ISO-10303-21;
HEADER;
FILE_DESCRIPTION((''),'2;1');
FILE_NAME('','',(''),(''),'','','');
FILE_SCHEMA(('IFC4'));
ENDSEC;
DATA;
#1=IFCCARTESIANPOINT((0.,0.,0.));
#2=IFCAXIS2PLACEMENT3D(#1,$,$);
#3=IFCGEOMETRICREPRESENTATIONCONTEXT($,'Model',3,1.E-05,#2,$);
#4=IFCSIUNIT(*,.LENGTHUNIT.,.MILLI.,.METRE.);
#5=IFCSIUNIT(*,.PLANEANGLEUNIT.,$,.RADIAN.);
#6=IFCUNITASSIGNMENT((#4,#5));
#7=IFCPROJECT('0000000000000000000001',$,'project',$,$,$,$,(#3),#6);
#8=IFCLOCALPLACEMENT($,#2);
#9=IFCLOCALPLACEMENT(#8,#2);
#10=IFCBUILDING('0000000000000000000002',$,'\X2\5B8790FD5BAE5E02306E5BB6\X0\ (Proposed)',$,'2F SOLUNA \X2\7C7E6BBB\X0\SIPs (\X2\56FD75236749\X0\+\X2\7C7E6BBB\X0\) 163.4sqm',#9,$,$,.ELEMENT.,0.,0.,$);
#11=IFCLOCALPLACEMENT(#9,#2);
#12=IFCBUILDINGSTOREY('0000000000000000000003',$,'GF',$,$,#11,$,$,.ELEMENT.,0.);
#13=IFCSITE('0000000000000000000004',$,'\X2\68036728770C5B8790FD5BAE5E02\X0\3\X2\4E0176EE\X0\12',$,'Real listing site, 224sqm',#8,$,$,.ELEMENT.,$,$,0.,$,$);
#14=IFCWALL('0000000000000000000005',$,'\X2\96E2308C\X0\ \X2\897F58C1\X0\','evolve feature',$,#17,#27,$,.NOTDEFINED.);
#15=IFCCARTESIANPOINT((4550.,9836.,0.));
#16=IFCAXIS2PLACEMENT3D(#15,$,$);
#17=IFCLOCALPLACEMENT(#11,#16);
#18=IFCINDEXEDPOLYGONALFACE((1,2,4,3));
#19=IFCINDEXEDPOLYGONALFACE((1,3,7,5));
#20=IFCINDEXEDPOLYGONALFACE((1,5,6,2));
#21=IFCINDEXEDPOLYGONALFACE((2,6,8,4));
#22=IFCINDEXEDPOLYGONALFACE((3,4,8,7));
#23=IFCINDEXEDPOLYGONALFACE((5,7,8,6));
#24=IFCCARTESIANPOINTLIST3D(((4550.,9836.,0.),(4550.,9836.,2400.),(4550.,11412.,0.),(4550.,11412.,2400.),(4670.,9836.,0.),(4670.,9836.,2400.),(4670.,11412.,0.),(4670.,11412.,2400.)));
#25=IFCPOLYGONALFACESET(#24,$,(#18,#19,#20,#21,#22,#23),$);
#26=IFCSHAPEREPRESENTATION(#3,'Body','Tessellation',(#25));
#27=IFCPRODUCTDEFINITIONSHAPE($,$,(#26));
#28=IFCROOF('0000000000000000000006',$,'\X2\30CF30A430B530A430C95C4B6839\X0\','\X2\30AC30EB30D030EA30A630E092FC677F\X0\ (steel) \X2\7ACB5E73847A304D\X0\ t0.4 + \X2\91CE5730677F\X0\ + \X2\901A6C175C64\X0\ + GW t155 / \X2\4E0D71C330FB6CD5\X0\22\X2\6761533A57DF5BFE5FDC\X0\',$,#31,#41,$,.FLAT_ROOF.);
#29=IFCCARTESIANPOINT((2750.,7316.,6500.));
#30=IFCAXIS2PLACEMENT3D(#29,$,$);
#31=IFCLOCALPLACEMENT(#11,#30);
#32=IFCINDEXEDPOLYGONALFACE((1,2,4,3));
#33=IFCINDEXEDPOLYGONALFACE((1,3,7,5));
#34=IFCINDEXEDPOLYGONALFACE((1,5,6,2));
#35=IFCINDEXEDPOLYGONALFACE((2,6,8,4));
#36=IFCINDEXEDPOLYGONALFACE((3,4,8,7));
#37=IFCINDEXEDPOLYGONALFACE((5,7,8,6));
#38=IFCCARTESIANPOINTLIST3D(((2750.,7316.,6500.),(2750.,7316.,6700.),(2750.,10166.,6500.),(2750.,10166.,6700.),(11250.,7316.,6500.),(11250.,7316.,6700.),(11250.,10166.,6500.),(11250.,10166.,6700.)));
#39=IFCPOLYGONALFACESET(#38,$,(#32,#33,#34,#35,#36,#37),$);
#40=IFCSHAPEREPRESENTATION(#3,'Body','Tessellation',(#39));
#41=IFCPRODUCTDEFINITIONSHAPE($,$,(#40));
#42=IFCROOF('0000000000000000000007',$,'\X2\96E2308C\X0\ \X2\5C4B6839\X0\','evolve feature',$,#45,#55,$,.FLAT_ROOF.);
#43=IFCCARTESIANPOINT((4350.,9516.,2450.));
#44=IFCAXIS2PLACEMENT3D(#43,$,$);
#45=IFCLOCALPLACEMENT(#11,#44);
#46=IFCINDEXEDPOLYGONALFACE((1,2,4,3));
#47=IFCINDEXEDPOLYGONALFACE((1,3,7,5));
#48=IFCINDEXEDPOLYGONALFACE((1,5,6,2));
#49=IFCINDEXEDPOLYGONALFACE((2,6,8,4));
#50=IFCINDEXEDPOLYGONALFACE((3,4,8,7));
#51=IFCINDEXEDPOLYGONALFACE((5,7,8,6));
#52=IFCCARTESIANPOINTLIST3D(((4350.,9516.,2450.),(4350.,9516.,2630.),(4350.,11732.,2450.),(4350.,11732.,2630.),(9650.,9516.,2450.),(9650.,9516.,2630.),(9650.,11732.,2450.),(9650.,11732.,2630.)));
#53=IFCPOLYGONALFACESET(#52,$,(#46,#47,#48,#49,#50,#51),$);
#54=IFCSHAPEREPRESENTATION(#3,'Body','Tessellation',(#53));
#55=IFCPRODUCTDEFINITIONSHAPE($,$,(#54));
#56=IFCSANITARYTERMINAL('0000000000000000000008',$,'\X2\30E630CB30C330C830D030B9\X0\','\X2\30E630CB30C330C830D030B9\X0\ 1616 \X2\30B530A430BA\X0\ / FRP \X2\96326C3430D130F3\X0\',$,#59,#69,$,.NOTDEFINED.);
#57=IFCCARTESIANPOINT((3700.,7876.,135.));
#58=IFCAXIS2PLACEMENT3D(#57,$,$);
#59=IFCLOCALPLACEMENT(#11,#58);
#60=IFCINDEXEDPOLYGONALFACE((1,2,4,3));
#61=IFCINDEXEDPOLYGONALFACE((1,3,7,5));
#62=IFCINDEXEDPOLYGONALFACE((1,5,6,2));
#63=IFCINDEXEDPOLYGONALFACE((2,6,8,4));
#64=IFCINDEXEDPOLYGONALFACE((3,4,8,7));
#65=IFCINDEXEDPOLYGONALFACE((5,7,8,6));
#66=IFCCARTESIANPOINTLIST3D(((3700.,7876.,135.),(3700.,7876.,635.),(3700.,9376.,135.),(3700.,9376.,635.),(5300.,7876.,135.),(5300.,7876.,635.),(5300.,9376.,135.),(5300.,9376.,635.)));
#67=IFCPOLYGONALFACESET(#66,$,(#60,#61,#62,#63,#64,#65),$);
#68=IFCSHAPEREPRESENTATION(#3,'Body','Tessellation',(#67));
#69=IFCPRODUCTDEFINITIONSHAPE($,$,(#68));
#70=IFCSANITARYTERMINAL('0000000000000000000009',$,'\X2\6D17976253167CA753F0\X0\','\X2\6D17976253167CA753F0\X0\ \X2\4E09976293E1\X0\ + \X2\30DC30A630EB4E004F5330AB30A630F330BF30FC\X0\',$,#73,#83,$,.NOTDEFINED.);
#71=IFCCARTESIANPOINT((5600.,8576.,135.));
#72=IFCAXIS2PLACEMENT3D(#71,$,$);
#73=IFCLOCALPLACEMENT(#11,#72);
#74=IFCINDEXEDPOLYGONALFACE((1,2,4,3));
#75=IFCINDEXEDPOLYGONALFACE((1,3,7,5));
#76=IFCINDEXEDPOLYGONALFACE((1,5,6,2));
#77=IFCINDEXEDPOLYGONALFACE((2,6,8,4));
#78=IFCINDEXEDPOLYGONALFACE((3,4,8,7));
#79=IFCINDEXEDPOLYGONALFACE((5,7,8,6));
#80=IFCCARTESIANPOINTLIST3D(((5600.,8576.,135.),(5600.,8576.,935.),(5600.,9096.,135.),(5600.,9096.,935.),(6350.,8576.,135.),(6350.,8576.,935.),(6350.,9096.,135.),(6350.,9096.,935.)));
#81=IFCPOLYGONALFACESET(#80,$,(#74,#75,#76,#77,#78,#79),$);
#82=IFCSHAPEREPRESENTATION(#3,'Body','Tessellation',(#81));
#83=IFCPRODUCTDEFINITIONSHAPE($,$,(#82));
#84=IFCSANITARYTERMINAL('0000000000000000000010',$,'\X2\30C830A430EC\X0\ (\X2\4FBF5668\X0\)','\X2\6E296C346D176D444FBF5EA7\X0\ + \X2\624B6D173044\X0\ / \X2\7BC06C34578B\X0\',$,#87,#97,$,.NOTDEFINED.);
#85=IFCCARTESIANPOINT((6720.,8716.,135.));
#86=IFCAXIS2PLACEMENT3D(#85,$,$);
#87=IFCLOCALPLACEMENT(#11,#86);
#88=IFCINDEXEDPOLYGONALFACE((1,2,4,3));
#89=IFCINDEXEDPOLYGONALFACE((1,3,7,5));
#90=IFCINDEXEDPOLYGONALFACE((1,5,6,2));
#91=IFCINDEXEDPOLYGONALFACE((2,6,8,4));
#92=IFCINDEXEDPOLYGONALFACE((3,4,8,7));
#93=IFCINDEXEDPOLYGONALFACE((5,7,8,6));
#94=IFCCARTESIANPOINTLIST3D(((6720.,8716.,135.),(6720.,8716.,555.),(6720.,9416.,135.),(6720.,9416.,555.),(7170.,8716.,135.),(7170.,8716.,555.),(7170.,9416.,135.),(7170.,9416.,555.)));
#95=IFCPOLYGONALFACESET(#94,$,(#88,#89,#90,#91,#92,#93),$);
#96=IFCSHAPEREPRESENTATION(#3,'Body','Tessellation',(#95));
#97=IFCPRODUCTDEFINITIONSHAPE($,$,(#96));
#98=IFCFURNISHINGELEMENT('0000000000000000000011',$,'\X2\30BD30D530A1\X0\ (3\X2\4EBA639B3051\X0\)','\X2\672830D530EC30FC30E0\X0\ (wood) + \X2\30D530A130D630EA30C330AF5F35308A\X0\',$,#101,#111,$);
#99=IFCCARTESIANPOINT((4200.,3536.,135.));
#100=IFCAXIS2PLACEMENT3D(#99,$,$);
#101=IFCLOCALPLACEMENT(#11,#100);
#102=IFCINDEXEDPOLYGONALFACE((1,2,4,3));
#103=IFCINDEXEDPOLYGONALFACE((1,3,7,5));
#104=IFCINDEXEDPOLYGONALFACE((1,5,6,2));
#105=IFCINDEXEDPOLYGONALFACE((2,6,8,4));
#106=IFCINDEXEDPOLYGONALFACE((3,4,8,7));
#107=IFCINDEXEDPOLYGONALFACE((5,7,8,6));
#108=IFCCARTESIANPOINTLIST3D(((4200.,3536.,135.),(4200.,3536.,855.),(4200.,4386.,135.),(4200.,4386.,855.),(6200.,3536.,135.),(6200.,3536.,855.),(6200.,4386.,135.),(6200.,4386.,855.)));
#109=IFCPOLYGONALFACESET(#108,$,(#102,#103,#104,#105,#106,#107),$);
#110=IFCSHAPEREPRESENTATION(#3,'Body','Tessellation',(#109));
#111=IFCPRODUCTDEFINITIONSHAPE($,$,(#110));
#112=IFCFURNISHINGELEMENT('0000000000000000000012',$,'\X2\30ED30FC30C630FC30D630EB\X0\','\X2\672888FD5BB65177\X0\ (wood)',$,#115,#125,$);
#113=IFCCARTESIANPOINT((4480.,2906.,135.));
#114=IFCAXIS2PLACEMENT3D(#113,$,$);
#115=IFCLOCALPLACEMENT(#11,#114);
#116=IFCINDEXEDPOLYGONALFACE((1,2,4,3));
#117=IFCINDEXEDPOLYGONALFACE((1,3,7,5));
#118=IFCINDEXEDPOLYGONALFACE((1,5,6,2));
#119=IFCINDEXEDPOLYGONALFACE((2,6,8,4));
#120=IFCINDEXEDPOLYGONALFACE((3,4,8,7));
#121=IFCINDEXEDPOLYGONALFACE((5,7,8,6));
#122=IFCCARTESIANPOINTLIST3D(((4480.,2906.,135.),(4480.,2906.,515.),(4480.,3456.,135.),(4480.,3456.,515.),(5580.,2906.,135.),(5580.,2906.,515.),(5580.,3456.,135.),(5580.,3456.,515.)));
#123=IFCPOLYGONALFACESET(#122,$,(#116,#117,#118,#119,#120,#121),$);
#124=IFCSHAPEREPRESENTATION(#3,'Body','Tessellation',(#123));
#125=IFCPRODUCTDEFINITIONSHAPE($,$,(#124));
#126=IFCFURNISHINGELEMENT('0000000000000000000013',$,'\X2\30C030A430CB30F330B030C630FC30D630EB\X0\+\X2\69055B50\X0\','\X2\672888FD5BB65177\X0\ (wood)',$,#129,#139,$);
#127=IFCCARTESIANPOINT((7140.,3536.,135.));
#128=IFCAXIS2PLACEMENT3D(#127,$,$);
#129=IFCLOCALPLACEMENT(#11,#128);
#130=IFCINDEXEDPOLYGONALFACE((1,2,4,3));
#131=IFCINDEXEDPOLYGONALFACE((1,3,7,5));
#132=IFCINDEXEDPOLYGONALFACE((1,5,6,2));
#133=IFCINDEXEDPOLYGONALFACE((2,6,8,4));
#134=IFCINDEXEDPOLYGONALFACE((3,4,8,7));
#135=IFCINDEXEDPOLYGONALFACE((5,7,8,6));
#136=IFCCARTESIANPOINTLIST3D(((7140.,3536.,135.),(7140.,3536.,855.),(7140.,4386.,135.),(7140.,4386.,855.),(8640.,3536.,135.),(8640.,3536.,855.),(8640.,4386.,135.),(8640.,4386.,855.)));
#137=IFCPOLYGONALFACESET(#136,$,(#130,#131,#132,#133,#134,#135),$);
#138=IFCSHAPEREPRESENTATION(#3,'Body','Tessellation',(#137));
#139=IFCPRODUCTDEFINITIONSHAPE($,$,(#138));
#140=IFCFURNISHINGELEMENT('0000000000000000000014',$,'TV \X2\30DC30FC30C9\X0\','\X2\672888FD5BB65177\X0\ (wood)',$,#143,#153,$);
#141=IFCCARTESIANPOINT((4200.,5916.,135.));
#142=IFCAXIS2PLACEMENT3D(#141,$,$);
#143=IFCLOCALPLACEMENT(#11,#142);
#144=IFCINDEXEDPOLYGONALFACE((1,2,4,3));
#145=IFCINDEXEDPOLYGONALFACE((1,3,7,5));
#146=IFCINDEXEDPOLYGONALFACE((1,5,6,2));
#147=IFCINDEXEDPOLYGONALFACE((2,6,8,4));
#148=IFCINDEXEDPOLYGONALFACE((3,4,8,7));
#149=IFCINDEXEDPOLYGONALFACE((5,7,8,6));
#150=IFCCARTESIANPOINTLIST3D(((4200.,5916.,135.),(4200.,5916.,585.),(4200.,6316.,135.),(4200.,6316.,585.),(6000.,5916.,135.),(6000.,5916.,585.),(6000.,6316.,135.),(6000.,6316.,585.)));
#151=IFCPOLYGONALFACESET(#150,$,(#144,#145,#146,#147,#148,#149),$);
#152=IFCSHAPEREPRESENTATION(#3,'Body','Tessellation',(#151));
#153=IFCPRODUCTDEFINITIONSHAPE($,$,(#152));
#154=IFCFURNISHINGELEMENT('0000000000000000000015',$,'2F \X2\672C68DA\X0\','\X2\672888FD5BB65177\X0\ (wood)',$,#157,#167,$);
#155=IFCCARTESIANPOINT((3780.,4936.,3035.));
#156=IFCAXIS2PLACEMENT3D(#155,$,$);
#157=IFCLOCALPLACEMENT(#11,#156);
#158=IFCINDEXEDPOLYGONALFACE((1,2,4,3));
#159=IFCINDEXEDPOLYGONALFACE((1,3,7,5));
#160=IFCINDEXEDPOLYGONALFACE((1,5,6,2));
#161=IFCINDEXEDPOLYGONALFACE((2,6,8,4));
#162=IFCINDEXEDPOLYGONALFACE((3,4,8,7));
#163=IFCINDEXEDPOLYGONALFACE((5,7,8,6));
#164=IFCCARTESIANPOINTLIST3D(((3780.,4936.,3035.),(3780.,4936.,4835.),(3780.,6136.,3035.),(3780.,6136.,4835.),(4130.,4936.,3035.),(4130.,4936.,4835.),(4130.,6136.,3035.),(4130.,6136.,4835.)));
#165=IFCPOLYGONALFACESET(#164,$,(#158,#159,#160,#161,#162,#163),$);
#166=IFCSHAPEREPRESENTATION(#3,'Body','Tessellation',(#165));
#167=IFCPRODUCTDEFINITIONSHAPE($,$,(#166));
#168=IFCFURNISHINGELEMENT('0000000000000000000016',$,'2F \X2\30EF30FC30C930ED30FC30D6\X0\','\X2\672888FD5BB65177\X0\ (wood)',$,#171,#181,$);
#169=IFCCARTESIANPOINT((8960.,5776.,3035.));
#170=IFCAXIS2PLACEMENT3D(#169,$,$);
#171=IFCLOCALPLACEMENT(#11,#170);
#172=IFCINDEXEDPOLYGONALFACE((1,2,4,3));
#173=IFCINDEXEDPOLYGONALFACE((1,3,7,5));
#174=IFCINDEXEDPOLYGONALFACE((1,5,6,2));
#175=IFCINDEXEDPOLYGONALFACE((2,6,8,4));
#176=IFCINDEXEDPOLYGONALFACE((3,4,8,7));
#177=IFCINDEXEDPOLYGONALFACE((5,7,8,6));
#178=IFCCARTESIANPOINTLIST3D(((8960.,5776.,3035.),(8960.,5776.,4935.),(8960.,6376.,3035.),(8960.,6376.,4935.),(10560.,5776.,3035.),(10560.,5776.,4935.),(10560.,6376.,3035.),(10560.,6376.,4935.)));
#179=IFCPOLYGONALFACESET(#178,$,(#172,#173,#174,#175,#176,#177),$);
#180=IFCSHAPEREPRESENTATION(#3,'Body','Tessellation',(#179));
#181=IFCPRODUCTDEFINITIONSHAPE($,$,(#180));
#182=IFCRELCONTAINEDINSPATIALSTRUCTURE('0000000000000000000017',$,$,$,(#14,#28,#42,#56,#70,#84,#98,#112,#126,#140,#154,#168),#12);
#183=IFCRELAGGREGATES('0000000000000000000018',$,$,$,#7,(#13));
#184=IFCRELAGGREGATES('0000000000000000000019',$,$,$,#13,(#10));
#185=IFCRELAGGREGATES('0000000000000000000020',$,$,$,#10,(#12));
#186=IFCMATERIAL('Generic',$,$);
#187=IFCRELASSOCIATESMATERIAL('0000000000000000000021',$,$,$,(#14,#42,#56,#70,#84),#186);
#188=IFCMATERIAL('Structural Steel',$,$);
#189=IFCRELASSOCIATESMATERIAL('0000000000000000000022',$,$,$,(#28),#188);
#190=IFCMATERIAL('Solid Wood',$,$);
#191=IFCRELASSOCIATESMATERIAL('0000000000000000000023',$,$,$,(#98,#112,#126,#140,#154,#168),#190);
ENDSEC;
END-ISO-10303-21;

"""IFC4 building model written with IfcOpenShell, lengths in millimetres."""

from ifc_helpers import new_model, si_unit, frame, frame_2d, origin, place, context, project, spatial, rectangle, extrude, material, element, save


model = new_model("IFC4")

# Units and contexts
model_context = context("Model", 3, precision=1e-05, world=origin())
ifc_project = project(units=[si_unit("LENGTHUNIT", "METRE", prefix="MILLI"), si_unit("PLANEANGLEUNIT", "RADIAN")], contexts=[model_context])

# Site, building, storey
site_placement = place(None, origin())
site = spatial("IfcSite", under=ifc_project, at=site_placement, Name="栃木県宇都宮市3丁目12", ObjectType="Real listing site, 224sqm", CompositionType="ELEMENT", RefElevation=0.0)
building_placement = place(site_placement, origin())
building = spatial("IfcBuilding", under=site, at=building_placement, Name="宇都宮市の家 (Proposed)", ObjectType="2F SOLUNA 籾殻SIPs (国産杉+籾殻) 163.4sqm", CompositionType="ELEMENT", ElevationOfRefHeight=0.0, ElevationOfTerrain=0.0)
storey_placement = place(building_placement, origin())
storey = spatial("IfcBuildingStorey", under=building, at=storey_placement, Name="GF", CompositionType="ELEMENT", Elevation=0.0)

# Shared definitions
ifc_material_1 = material(Name="Generic")

# Shared definitions
ifc_material_2 = material(Name="Solid Wood")

# Wall
wall_1_placement = place(storey_placement, frame((4550.0, 9836.0, 0.0)))
element("IfcWall", 1, at=wall_1_placement, inside=storey, material=ifc_material_1, Name="離れ 西壁", Description="evolve feature", PredefinedType="NOTDEFINED", context=model_context, shape_type="SweptSolid", body=[
    extrude(rectangle(XDim=120.0, YDim=1576.0, at=frame_2d((60.0, 788.0))), frame((4550.0, 9836.0, 0.0)), (0.0, 0.0, 1.0), 2400.0),
])

# Roofs
ifc_material_3 = material(Name="Structural Steel")
roof_1_placement = place(storey_placement, frame((2750.0, 7316.0, 6500.0)))
element("IfcRoof", 2, at=roof_1_placement, inside=storey, material=ifc_material_3, Name="ハイサイド屋根", Description="ガルバリウム鋼板 (steel) 立平葺き t0.4 + 野地板 + 通気層 + GW t155 / 不燃・法22条区域対応", PredefinedType="FLAT_ROOF", context=model_context, shape_type="SweptSolid", body=[
    extrude(rectangle(XDim=8500.0, YDim=2850.0, at=frame_2d((4250.0, 1425.0))), frame((2750.0, 7316.0, 6500.0)), (0.0, 0.0, 1.0), 200.0),
])
roof_2_placement = place(storey_placement, frame((4350.0, 9516.0, 2450.0)))
element("IfcRoof", 3, at=roof_2_placement, inside=storey, material=ifc_material_1, Name="離れ 屋根", Description="evolve feature", PredefinedType="FLAT_ROOF", context=model_context, shape_type="SweptSolid", body=[
    extrude(rectangle(XDim=5300.0, YDim=2216.0, at=frame_2d((2650.0, 1108.0))), frame((4350.0, 9516.0, 2450.0)), (0.0, 0.0, 1.0), 180.0),
])

# Sanitary terminals
sanitary_terminal_1_placement = place(storey_placement, frame((3700.0, 7876.0, 135.0)))
element("IfcSanitaryTerminal", 4, at=sanitary_terminal_1_placement, inside=storey, material=ifc_material_1, Name="ユニットバス", Description="ユニットバス 1616 サイズ / FRP 防水パン", PredefinedType="NOTDEFINED", context=model_context, shape_type="SweptSolid", body=[
    extrude(rectangle(XDim=1600.0, YDim=1500.0, at=frame_2d((800.0, 750.0))), frame((3700.0, 7876.0, 135.0)), (0.0, 0.0, 1.0), 500.0),
])
sanitary_terminal_2_placement = place(storey_placement, frame((5600.0, 8576.0, 135.0)))
element("IfcSanitaryTerminal", 5, at=sanitary_terminal_2_placement, inside=storey, material=ifc_material_1, Name="洗面化粧台", Description="洗面化粧台 三面鏡 + ボウル一体カウンター", PredefinedType="NOTDEFINED", context=model_context, shape_type="SweptSolid", body=[
    extrude(rectangle(XDim=750.0, YDim=520.0, at=frame_2d((375.0, 260.0))), frame((5600.0, 8576.0, 135.0)), (0.0, 0.0, 1.0), 800.0),
])
sanitary_terminal_3_placement = place(storey_placement, frame((6720.0, 8716.0, 135.0)))
element("IfcSanitaryTerminal", 6, at=sanitary_terminal_3_placement, inside=storey, material=ifc_material_1, Name="トイレ (便器)", Description="温水洗浄便座 + 手洗い / 節水型", PredefinedType="NOTDEFINED", context=model_context, shape_type="SweptSolid", body=[
    extrude(rectangle(XDim=450.0, YDim=700.0, at=frame_2d((225.0, 350.0))), frame((6720.0, 8716.0, 135.0)), (0.0, 0.0, 1.0), 420.0),
])

# Furnishing elements
furnishing_1_placement = place(storey_placement, frame((4200.0, 3536.0, 135.0)))
element("IfcFurnishingElement", 7, at=furnishing_1_placement, inside=storey, material=ifc_material_2, Name="ソファ (3人掛け)", Description="木フレーム (wood) + ファブリック張り", context=model_context, shape_type="SweptSolid", body=[
    extrude(rectangle(XDim=2000.0, YDim=850.0, at=frame_2d((1000.0, 425.0))), frame((4200.0, 3536.0, 135.0)), (0.0, 0.0, 1.0), 720.0),
])
furnishing_2_placement = place(storey_placement, frame((4480.0, 2906.0, 135.0)))
element("IfcFurnishingElement", 8, at=furnishing_2_placement, inside=storey, material=ifc_material_2, Name="ローテーブル", Description="木製家具 (wood)", context=model_context, shape_type="SweptSolid", body=[
    extrude(rectangle(XDim=1100.0, YDim=550.0, at=frame_2d((550.0, 275.0))), frame((4480.0, 2906.0, 135.0)), (0.0, 0.0, 1.0), 380.0),
])
furnishing_3_placement = place(storey_placement, frame((7140.0, 3536.0, 135.0)))
element("IfcFurnishingElement", 9, at=furnishing_3_placement, inside=storey, material=ifc_material_2, Name="ダイニングテーブル+椅子", Description="木製家具 (wood)", context=model_context, shape_type="SweptSolid", body=[
    extrude(rectangle(XDim=1500.0, YDim=850.0, at=frame_2d((750.0, 425.0))), frame((7140.0, 3536.0, 135.0)), (0.0, 0.0, 1.0), 720.0),
])
furnishing_4_placement = place(storey_placement, frame((4200.0, 5916.0, 135.0)))
element("IfcFurnishingElement", 10, at=furnishing_4_placement, inside=storey, material=ifc_material_2, Name="TV ボード", Description="木製家具 (wood)", context=model_context, shape_type="SweptSolid", body=[
    extrude(rectangle(XDim=1800.0, YDim=400.0, at=frame_2d((900.0, 200.0))), frame((4200.0, 5916.0, 135.0)), (0.0, 0.0, 1.0), 450.0),
])
furnishing_5_placement = place(storey_placement, frame((3780.0, 4936.0, 3035.0)))
element("IfcFurnishingElement", 11, at=furnishing_5_placement, inside=storey, material=ifc_material_2, Name="2F 本棚", Description="木製家具 (wood)", context=model_context, shape_type="SweptSolid", body=[
    extrude(rectangle(XDim=350.0, YDim=1200.0, at=frame_2d((175.0, 600.0))), frame((3780.0, 4936.0, 3035.0)), (0.0, 0.0, 1.0), 1800.0),
])
furnishing_6_placement = place(storey_placement, frame((8960.0, 5776.0, 3035.0)))
element("IfcFurnishingElement", 12, at=furnishing_6_placement, inside=storey, material=ifc_material_2, Name="2F ワードローブ", Description="木製家具 (wood)", context=model_context, shape_type="SweptSolid", body=[
    extrude(rectangle(XDim=1600.0, YDim=600.0, at=frame_2d((800.0, 300.0))), frame((8960.0, 5776.0, 3035.0)), (0.0, 0.0, 1.0), 1900.0),
])

save(model, "model.ifc")
